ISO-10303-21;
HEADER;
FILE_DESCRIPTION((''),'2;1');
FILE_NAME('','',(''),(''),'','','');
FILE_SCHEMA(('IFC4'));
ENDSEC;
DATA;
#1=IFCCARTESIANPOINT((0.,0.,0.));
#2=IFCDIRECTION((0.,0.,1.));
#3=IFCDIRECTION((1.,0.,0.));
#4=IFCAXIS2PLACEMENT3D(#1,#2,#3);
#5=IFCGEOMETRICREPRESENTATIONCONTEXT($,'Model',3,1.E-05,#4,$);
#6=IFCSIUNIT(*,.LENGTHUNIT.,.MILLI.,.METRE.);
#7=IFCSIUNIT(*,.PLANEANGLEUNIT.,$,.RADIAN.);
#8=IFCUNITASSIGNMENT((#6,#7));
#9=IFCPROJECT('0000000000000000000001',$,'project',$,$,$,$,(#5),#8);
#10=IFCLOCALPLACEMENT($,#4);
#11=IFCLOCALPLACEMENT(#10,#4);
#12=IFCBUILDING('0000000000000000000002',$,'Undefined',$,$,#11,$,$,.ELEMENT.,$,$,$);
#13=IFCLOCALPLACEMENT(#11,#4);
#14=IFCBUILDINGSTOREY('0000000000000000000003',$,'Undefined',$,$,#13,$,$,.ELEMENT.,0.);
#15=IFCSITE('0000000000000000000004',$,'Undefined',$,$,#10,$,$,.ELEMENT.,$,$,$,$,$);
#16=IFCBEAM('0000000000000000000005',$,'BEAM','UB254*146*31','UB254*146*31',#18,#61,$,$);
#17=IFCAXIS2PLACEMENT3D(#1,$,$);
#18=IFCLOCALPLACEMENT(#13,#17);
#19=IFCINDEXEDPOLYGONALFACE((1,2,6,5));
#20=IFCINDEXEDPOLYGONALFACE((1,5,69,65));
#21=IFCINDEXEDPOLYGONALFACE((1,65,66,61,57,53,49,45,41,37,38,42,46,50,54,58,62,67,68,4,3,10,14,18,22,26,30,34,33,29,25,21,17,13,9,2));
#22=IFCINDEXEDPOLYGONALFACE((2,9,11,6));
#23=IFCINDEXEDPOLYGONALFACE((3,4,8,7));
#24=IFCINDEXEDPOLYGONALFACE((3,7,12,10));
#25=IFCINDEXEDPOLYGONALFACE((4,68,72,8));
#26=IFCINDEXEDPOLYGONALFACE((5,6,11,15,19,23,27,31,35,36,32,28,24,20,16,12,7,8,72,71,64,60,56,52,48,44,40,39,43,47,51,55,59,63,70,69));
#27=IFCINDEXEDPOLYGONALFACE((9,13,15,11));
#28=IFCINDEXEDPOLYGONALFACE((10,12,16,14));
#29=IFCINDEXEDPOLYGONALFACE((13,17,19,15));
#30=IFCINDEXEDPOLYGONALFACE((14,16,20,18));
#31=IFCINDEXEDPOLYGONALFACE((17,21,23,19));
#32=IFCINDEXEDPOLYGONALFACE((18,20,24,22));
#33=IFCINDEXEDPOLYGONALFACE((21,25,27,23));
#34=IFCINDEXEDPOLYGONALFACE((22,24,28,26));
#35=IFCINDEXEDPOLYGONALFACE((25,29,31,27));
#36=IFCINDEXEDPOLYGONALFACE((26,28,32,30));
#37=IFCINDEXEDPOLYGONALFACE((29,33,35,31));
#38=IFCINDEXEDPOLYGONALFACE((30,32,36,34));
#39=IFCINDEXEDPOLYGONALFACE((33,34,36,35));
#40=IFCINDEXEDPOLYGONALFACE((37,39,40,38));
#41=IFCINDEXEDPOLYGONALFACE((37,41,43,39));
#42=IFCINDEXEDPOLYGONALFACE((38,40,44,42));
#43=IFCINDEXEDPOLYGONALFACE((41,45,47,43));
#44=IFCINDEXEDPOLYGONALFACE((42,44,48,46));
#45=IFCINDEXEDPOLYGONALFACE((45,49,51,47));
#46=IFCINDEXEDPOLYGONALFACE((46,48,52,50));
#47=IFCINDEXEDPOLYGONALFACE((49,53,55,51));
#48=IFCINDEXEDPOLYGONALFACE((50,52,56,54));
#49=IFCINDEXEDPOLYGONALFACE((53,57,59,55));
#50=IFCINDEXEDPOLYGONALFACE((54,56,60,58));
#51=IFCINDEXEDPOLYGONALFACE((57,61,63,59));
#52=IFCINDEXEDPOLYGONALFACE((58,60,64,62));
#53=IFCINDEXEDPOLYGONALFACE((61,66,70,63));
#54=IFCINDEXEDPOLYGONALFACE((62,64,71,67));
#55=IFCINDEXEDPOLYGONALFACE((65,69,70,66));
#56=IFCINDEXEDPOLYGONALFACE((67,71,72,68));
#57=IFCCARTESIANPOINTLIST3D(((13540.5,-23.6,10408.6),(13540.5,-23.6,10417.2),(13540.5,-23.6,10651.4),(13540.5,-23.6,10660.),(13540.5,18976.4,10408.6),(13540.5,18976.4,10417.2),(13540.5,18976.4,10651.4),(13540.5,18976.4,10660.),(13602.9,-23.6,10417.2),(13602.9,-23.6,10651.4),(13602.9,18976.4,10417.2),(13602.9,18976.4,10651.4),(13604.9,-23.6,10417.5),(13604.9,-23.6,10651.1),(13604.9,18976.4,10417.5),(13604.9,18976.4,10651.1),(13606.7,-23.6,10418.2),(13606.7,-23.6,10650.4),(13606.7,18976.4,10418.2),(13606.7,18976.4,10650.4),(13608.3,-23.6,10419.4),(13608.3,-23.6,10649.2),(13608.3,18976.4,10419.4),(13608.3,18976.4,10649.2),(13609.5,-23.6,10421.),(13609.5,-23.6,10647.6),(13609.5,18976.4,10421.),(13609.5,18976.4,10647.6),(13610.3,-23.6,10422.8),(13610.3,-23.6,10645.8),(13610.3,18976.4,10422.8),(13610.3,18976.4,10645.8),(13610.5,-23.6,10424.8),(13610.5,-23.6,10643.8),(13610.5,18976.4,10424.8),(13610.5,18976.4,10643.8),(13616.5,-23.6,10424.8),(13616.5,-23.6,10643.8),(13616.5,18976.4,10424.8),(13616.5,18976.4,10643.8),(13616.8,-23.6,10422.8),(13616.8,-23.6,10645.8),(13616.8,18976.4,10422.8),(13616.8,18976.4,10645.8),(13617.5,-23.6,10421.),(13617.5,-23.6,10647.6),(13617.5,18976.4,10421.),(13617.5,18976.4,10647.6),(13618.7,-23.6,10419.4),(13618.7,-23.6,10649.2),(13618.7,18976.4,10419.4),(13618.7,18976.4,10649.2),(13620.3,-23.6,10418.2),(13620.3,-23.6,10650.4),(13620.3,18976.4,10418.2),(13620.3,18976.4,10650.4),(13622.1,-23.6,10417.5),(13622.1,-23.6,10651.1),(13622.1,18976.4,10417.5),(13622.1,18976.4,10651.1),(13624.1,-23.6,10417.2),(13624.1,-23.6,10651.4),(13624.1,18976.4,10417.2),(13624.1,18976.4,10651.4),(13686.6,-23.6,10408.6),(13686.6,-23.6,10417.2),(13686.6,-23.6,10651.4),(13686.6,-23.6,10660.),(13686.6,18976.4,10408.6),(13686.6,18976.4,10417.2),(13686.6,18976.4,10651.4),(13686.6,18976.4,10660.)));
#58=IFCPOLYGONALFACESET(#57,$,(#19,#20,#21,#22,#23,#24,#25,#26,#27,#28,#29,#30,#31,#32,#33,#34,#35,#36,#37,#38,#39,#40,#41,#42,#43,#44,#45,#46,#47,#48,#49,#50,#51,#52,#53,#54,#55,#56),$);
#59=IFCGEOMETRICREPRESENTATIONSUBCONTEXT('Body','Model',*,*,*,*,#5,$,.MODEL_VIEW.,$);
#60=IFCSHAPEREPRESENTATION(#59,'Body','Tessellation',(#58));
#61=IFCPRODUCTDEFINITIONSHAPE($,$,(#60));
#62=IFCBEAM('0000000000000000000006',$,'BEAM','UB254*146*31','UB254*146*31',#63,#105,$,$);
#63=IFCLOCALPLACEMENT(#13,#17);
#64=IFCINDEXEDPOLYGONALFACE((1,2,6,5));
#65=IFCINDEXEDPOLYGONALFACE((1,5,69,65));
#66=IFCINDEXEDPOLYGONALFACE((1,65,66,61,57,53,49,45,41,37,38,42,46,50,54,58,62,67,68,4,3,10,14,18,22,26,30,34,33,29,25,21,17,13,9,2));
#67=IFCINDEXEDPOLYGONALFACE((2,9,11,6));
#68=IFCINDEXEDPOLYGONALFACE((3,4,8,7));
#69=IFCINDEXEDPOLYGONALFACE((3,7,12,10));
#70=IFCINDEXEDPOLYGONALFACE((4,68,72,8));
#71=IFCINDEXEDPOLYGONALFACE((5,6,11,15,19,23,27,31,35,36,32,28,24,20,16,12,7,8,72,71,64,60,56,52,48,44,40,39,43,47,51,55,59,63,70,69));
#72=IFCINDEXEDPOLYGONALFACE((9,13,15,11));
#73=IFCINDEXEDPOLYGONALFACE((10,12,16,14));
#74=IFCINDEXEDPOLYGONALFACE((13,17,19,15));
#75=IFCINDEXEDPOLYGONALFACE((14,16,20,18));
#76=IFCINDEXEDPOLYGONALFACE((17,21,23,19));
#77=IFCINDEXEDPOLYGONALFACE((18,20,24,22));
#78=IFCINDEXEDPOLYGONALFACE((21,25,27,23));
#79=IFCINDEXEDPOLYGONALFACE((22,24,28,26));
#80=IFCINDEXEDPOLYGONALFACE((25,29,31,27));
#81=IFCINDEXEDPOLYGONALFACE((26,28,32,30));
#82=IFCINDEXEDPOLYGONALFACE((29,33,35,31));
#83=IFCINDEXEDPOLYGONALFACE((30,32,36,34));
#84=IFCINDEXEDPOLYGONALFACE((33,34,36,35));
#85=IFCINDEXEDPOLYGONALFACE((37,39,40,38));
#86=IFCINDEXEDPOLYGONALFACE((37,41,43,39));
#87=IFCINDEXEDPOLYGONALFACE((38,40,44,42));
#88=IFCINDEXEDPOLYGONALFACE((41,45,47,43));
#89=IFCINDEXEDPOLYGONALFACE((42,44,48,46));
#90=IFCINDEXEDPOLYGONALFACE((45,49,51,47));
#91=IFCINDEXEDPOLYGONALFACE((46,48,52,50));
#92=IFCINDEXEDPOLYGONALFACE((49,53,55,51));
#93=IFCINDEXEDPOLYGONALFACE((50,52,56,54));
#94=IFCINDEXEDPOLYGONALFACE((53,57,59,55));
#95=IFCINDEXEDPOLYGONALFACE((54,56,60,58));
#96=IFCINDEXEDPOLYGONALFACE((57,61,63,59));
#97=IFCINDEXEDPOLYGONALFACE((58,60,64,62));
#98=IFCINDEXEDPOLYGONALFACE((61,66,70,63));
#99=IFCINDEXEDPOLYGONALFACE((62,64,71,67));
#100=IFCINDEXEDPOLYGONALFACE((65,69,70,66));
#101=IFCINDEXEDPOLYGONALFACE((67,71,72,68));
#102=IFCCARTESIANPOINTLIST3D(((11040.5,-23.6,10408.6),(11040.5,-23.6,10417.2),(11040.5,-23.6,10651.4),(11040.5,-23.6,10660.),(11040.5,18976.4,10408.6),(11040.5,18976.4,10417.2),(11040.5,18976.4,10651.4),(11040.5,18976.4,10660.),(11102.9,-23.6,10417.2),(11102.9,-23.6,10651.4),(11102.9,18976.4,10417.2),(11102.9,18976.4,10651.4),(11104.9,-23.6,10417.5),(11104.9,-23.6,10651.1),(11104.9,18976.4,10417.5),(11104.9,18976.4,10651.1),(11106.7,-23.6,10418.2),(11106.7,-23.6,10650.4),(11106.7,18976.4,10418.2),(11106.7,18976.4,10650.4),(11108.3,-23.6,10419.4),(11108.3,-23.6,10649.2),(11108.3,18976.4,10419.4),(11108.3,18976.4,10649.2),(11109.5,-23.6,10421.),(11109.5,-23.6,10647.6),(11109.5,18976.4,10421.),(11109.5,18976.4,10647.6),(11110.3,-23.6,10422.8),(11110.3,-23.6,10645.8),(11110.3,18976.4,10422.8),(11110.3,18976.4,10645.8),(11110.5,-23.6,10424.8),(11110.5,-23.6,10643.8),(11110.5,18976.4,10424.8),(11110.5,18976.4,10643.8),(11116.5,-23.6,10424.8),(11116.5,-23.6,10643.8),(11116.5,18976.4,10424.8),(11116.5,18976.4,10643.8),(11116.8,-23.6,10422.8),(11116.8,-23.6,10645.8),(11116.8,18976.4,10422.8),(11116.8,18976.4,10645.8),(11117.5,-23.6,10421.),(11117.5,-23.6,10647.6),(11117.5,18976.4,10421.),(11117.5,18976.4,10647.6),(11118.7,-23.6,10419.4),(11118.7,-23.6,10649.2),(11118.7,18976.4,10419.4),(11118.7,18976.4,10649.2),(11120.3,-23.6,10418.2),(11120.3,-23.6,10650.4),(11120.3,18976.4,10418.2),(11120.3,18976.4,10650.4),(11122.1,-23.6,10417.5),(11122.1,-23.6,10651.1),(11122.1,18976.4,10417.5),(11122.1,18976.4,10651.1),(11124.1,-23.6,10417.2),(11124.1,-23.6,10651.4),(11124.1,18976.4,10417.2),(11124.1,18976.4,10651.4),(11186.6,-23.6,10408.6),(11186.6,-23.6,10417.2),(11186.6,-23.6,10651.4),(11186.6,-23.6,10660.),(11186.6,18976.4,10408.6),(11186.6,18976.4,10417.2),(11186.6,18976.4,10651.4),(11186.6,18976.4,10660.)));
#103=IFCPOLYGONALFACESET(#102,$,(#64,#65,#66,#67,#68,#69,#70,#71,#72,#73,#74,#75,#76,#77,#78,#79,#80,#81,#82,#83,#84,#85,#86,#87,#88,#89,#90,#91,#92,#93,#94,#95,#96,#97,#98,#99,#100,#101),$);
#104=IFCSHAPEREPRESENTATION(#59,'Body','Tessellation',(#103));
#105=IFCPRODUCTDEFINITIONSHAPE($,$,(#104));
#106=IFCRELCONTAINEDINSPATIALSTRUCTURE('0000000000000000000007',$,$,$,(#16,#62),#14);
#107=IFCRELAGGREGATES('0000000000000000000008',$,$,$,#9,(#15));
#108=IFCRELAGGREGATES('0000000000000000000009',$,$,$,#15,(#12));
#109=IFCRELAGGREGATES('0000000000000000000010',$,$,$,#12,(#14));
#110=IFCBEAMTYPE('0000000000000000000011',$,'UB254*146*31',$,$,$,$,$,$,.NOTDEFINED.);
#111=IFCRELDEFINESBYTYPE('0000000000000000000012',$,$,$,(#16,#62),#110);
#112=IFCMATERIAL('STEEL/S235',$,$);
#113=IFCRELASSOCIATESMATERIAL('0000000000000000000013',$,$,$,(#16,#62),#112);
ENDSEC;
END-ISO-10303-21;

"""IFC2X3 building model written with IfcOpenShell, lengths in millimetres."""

from ifc_helpers import new_model, si_unit, frame, origin_with_axes, origin_2d_with_axis, place, context, subcontext, project, spatial, i_section, extrude, material, type_object, element, save


model = new_model("IFC2X3")

# Units and contexts
model_context = context("Model", 3, precision=1e-05, world=origin_with_axes())
body_context = subcontext(model_context, "Body", "Model", "MODEL_VIEW")
ifc_project = project(units=[si_unit("LENGTHUNIT", "METRE", prefix="MILLI"), si_unit("PLANEANGLEUNIT", "RADIAN")], contexts=[model_context])

# Site, building, storey
site_placement = place(None, origin_with_axes())
site = spatial("IfcSite", under=ifc_project, at=site_placement, Name="Undefined", CompositionType="ELEMENT")
building_placement = place(site_placement, origin_with_axes())
building = spatial("IfcBuilding", under=site, at=building_placement, Name="Undefined", CompositionType="ELEMENT")
storey_placement = place(building_placement, origin_with_axes())
storey = spatial("IfcBuildingStorey", under=building, at=storey_placement, Name="Undefined", CompositionType="ELEMENT", Elevation=0.0)

# Shared definitions
ifc_material = material(Name="STEEL/S235")

# Beams
beam_type_1 = type_object("IfcBeamType", Name="UB254*146*31", PredefinedType="NOTDEFINED")
for number, where, z_axis, x_axis, name in (
    (1, (13613.5, -23.6, 10534.3), (0.0, 0.0, 1.0), (0.0, 1.0, 0.0), "BEAM"),
    (2, (11113.5, -23.6, 10534.3), (0.0, 0.0, 1.0), (0.0, 1.0, 0.0), "BEAM"),
):
    element("IfcBeam", number, at=place(storey_placement, frame(where, z_axis=z_axis, x_axis=x_axis)), inside=storey, type_object=beam_type_1, material=ifc_material, Name=name, Description="UB254*146*31", ObjectType="UB254*146*31", context=body_context, shape_type="SweptSolid", body=[
        extrude(i_section(OverallWidth=146.1, OverallDepth=251.4, WebThickness=6.0, FlangeThickness=8.6, FilletRadius=7.6, at=origin_2d_with_axis()), frame((19000.0, 0.0, 0.0), z_axis=(-1.0, 0.0, 0.0), x_axis=(0.0, -1.0, 0.0)), (0.0, 0.0, 1.0), 19000.0),
    ])

save(model, "model.ifc")
